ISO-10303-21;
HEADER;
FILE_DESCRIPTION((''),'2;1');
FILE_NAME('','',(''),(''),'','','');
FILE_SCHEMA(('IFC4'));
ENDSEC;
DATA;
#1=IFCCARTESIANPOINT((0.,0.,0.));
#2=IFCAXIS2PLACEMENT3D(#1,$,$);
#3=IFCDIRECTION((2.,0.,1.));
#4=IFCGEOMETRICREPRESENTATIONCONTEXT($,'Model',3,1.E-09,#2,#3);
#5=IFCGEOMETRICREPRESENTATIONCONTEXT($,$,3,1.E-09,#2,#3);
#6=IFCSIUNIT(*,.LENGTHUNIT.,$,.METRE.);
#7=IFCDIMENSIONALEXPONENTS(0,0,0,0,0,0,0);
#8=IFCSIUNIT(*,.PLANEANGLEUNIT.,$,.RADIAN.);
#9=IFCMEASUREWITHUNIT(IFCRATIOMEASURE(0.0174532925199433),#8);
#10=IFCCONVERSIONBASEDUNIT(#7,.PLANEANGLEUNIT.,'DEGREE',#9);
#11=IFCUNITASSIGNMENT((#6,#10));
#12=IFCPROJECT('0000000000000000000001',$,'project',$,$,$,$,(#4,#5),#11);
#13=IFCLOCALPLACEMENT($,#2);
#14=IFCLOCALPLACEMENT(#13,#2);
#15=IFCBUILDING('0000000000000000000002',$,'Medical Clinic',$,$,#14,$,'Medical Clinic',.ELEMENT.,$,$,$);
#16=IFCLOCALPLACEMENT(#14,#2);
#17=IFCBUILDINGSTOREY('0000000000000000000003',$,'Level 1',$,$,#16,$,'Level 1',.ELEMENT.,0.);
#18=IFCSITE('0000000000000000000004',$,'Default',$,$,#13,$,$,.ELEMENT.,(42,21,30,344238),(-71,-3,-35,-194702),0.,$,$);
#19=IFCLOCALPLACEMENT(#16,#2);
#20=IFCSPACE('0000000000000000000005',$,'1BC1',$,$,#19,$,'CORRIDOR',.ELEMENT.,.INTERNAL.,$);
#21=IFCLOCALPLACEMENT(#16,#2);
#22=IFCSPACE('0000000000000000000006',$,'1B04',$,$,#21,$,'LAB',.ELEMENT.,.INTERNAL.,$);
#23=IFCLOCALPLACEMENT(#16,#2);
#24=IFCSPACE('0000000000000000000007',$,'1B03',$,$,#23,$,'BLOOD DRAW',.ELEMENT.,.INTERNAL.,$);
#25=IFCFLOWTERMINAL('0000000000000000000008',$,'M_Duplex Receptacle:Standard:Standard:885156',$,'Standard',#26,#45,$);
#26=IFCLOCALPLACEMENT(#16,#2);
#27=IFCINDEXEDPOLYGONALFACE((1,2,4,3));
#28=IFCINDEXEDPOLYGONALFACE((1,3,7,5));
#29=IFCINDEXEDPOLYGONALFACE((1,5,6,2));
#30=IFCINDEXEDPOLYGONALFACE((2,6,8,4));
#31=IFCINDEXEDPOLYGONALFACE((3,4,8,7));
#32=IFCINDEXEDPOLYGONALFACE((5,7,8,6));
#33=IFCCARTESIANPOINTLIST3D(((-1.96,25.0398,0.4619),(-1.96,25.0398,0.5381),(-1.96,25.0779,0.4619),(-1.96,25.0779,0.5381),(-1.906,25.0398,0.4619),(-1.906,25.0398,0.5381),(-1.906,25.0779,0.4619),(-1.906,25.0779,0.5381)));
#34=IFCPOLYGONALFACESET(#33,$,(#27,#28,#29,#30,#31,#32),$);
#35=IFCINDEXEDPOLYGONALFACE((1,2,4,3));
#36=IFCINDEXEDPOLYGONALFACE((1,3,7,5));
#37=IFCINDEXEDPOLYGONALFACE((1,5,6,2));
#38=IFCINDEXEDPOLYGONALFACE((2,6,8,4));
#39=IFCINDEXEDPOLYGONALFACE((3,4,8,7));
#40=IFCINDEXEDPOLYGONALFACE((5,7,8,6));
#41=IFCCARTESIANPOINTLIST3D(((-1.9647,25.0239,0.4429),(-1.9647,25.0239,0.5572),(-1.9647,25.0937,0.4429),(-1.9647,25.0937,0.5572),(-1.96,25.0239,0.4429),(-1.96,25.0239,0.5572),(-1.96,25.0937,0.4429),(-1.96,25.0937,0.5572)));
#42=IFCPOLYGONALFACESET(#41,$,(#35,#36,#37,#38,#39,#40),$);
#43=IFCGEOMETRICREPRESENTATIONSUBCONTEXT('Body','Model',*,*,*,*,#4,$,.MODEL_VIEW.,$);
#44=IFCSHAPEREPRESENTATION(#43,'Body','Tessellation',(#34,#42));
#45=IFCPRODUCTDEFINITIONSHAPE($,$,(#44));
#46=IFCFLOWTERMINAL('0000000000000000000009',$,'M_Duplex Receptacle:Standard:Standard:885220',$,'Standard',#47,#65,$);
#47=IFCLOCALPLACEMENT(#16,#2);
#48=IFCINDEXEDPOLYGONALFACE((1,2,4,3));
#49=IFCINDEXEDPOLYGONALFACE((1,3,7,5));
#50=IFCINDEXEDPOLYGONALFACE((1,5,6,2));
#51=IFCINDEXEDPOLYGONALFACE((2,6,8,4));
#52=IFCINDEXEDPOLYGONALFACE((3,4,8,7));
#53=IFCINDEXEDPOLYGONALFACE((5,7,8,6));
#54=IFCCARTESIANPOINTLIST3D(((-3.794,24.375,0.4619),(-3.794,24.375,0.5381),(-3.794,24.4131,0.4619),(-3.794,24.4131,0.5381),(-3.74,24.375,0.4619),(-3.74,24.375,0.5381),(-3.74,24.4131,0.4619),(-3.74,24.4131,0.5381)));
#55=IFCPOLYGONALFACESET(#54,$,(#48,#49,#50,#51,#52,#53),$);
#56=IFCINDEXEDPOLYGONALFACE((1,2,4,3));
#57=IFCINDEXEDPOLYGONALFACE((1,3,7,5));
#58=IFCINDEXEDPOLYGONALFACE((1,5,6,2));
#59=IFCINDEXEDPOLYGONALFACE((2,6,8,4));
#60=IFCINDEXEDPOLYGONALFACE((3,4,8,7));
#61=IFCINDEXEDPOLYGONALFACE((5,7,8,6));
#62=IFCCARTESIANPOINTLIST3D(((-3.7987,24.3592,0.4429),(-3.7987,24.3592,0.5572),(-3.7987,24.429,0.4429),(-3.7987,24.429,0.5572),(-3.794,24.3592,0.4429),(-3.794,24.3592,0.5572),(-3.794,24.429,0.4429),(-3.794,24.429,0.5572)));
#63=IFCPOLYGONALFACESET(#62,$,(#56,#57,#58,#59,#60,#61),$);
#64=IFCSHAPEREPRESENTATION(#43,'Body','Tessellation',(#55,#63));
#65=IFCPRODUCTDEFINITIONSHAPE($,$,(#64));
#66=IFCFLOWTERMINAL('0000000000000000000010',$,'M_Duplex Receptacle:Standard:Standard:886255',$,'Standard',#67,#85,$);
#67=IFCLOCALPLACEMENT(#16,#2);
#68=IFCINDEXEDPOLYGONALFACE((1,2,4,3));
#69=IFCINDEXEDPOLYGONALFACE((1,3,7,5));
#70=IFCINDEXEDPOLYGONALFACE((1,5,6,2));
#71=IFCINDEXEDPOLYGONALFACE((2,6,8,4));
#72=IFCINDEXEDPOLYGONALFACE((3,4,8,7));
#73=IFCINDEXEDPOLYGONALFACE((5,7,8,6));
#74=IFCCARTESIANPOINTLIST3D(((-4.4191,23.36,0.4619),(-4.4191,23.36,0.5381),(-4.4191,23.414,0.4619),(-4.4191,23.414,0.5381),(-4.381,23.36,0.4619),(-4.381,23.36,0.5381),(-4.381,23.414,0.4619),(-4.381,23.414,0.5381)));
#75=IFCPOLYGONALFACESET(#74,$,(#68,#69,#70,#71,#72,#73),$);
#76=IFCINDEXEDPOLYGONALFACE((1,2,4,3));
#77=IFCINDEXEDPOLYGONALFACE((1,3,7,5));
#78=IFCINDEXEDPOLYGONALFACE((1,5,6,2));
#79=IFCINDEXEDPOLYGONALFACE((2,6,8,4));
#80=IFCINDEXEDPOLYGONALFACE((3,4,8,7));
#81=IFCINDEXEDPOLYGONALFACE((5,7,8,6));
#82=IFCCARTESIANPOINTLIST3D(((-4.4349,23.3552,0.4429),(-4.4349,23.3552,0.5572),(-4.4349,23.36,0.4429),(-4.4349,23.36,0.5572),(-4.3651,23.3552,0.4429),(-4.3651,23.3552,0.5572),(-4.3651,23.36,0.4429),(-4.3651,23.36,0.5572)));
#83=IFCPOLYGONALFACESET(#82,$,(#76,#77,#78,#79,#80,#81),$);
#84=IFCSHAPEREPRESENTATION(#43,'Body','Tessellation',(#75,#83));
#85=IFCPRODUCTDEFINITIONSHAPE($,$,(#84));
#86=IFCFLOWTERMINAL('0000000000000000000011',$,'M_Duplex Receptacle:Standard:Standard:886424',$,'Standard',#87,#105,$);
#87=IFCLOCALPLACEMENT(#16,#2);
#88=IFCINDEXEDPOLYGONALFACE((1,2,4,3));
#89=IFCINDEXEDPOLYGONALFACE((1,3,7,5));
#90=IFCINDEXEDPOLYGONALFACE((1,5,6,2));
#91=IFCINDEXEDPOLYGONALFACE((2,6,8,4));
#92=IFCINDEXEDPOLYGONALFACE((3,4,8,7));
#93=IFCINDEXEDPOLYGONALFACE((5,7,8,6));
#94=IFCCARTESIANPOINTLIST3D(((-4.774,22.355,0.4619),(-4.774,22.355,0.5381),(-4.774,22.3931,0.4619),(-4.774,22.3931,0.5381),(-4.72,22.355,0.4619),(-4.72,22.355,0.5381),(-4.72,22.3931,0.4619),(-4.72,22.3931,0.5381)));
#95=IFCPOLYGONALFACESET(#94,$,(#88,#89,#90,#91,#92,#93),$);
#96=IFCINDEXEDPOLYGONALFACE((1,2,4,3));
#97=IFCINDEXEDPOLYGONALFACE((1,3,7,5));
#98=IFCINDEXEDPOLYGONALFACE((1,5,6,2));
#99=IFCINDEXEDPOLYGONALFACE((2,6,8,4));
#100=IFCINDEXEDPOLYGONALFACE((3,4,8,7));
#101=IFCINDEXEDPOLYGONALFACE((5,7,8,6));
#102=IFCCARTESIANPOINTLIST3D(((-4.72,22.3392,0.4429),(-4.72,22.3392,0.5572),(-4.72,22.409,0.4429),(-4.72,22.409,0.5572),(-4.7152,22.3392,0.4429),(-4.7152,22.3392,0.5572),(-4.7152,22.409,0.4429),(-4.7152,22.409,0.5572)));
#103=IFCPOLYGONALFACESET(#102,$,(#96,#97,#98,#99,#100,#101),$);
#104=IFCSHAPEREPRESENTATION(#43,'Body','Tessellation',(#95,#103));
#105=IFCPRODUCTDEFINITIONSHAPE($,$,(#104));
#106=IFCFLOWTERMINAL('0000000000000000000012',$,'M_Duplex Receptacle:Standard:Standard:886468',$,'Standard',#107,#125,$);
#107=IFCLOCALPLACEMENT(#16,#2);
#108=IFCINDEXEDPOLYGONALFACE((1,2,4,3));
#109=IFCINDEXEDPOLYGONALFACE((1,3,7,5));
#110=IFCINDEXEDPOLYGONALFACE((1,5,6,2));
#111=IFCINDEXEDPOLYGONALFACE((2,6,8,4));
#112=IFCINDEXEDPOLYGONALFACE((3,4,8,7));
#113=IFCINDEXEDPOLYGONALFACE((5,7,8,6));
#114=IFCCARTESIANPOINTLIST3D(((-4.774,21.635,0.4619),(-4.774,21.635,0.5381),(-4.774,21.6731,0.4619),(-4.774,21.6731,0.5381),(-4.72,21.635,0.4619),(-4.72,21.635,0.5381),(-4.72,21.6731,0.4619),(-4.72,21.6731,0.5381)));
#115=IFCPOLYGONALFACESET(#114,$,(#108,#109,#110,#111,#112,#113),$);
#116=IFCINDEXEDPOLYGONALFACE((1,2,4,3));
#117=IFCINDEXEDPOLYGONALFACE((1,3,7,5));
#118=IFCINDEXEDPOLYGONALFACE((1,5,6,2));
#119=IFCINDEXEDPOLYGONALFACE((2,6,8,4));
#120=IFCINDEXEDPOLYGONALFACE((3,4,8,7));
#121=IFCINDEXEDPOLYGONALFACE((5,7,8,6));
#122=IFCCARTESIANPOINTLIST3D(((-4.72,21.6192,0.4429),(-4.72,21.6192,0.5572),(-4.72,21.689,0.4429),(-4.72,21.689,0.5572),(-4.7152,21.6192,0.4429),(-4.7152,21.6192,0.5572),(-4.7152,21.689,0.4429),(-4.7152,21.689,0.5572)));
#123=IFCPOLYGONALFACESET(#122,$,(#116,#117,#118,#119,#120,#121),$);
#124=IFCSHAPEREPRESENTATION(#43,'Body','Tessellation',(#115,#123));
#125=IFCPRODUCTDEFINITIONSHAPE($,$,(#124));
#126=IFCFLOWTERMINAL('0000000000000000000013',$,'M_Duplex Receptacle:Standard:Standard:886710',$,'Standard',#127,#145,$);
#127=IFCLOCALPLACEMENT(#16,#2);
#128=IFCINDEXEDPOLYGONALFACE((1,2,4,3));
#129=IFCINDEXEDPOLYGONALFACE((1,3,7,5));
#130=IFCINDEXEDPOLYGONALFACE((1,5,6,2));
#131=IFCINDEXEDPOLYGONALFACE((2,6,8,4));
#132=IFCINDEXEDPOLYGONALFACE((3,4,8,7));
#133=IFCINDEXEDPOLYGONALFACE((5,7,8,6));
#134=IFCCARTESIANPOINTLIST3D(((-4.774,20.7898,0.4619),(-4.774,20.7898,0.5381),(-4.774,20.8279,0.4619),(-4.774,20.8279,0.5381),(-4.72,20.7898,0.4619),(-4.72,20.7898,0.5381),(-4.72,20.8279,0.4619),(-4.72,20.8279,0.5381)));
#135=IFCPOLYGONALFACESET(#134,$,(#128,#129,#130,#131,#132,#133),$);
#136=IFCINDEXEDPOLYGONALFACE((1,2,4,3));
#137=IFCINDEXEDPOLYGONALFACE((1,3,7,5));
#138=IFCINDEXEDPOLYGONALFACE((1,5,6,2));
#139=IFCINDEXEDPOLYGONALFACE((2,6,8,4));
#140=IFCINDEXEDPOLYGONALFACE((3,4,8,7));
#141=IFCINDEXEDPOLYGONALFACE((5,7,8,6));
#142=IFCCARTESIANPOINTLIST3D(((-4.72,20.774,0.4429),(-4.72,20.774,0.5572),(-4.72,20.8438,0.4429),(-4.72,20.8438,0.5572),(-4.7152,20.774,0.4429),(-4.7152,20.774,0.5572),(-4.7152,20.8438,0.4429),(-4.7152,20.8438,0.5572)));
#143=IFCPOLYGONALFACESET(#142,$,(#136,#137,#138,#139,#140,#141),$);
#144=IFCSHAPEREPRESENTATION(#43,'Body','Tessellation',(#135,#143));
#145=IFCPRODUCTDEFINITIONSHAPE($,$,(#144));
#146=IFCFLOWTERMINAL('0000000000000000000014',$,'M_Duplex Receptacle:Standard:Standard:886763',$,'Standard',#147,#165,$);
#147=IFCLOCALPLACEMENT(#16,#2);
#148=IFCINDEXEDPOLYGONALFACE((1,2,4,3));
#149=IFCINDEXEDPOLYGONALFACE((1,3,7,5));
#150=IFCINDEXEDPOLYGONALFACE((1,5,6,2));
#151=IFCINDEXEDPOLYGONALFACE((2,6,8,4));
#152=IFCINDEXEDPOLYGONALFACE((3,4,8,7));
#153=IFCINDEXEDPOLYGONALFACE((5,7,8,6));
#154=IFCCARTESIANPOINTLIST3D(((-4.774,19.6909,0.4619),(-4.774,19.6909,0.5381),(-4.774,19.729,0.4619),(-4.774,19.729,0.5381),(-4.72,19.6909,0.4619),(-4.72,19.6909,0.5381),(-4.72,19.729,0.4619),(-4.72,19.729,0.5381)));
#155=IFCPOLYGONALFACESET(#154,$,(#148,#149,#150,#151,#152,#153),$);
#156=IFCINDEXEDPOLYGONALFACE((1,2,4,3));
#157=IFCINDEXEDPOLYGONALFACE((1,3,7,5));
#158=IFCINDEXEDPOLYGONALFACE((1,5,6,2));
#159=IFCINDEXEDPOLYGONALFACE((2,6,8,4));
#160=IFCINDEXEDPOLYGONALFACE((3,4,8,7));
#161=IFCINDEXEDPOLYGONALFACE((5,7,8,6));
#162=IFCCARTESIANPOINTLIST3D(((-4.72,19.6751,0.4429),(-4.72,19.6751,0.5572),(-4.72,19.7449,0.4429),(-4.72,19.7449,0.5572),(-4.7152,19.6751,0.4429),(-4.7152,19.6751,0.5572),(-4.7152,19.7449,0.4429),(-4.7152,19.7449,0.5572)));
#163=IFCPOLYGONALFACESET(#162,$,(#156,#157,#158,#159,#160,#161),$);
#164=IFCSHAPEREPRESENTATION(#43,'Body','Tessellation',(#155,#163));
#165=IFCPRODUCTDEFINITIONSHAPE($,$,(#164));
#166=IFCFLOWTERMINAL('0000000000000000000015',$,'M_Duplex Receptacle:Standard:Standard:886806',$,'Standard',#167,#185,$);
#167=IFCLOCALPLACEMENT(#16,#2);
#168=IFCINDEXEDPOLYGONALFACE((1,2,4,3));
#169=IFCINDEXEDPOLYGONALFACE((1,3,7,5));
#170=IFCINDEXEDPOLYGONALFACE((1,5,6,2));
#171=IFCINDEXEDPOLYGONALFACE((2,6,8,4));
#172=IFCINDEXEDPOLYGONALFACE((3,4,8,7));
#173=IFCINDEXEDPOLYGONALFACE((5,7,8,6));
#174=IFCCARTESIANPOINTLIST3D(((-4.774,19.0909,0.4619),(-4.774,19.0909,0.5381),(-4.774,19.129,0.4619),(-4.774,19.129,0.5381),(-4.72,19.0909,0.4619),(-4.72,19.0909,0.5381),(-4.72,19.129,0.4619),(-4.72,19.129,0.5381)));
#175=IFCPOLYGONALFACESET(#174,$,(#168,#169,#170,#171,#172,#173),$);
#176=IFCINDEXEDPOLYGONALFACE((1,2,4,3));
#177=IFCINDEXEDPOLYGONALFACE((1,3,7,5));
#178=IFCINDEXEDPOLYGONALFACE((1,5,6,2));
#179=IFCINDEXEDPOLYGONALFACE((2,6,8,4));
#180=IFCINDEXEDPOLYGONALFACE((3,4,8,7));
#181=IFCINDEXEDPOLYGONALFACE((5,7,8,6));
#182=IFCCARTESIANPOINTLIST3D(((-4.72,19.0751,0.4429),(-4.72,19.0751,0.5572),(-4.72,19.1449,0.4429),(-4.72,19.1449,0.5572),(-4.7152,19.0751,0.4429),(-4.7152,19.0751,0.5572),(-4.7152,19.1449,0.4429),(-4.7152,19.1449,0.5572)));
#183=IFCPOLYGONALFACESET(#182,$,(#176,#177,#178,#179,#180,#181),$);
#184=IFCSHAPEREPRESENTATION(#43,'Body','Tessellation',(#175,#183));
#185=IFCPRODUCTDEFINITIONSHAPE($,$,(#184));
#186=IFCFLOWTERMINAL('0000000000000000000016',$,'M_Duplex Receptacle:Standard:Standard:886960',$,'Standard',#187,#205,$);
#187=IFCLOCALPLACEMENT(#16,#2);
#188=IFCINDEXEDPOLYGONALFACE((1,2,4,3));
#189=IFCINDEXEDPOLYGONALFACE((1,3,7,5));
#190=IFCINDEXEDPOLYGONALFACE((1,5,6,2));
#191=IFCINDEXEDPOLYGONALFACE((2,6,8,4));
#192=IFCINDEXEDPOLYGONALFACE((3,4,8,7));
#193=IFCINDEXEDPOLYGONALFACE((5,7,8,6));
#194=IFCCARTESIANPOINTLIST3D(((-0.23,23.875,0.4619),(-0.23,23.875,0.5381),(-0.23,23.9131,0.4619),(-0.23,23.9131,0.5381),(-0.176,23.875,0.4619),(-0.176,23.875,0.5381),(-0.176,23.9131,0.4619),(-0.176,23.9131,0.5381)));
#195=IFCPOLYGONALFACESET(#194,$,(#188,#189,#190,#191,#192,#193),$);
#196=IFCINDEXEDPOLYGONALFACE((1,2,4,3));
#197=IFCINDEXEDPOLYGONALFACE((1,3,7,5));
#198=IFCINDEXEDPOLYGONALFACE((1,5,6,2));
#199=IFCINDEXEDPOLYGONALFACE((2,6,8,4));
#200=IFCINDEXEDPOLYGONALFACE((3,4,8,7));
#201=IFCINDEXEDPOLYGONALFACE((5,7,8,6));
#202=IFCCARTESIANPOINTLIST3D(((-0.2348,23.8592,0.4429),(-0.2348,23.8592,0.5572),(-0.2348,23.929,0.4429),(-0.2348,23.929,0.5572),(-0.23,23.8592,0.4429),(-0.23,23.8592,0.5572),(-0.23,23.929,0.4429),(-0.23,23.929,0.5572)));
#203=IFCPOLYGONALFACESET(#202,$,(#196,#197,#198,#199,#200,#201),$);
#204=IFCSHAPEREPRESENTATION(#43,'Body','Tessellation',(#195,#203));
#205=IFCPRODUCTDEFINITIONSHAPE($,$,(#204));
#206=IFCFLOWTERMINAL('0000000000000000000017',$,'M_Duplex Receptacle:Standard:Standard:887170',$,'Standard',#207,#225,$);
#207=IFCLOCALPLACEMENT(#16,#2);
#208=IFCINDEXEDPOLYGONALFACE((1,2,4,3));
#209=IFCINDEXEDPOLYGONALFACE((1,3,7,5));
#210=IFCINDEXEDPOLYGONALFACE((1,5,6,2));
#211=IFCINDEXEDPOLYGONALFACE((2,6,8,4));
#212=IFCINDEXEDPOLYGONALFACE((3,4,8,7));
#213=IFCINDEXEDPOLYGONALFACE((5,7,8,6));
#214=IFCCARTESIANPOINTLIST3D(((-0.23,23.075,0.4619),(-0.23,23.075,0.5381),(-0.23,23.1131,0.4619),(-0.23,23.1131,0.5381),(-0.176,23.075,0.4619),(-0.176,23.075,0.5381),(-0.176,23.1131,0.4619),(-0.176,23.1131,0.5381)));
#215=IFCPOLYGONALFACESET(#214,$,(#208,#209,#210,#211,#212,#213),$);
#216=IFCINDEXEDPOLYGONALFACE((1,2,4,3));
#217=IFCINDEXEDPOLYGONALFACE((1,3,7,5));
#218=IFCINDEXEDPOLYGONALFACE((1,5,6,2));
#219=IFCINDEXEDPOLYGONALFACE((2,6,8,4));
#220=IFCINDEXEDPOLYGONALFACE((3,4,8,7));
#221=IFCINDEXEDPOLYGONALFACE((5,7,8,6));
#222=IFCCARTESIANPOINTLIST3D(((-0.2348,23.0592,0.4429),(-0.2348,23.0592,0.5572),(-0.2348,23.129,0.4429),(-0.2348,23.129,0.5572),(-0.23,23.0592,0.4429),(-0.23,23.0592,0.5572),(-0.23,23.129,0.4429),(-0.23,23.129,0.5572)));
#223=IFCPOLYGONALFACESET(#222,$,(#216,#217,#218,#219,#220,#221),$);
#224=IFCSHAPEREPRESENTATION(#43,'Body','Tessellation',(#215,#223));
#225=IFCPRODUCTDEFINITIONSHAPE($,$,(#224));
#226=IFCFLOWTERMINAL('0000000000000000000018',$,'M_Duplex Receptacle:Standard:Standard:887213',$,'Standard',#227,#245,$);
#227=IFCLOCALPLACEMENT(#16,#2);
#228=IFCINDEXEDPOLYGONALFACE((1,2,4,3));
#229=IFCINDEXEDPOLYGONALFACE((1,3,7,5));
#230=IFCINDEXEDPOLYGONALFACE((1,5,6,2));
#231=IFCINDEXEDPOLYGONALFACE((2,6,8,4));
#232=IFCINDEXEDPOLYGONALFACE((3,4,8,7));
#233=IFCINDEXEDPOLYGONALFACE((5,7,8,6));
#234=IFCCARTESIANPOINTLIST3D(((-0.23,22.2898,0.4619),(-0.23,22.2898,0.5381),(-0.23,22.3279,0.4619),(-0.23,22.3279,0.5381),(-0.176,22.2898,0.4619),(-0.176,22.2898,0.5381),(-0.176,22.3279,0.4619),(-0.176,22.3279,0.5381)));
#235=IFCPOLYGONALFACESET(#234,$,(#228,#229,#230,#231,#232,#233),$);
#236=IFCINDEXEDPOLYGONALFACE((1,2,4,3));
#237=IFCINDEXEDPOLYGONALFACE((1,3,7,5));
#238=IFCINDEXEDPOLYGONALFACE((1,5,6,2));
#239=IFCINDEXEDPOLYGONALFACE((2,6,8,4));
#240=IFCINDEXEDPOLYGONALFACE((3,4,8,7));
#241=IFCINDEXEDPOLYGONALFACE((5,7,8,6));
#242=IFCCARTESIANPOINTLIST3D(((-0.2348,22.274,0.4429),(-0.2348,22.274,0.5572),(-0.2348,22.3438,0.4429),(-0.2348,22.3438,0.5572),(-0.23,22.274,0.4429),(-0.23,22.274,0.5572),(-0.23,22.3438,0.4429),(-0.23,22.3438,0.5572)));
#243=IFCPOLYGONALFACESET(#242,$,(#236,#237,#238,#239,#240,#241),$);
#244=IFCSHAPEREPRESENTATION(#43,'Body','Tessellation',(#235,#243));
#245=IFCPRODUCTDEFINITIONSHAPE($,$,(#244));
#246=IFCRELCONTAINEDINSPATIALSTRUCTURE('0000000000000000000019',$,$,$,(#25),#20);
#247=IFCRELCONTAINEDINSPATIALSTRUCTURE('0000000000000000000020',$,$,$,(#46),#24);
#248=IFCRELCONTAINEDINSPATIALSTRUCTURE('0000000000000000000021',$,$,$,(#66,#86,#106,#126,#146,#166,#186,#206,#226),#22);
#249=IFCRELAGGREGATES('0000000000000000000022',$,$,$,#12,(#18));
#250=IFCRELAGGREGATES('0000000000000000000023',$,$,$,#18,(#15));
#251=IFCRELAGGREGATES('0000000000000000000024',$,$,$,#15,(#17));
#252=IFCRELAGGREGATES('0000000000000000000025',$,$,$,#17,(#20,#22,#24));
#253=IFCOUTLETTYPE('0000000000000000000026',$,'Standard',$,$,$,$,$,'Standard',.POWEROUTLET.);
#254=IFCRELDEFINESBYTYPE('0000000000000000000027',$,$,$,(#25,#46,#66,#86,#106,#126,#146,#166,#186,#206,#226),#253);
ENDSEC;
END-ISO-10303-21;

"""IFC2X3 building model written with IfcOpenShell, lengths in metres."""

from ifc_helpers import new_model, entity, si_unit, converted_unit, direction, frame, frame_2d, origin, origin_2d_with_axis, place, context, subcontext, project, spatial, rectangle, extrude, source, transform, mapped, type_object, type_shapes, element, save


model = new_model("IFC2X3")

# Units and contexts
model_context = context("Model", 3, precision=1e-09, world=origin(), true_north=direction((2.0, 0.0, 1.0)))
context_of_model = context(None, 3, precision=1e-09, world=origin(), true_north=direction((2.0, 0.0, 1.0)))
body_context = subcontext(model_context, "Body", "Model", "MODEL_VIEW")
ifc_project = project(units=[si_unit("LENGTHUNIT", "METRE"), converted_unit("PLANEANGLEUNIT", "DEGREE", entity("IfcRatioMeasure", 0.0174532925199433), si_unit("PLANEANGLEUNIT", "RADIAN"), dimensions=[0, 0, 0, 0, 0, 0, 0])], contexts=[model_context, context_of_model])

# Site, building, storey
site_placement = place(None, origin())
site = spatial("IfcSite", under=ifc_project, at=site_placement, Name="Default", CompositionType="ELEMENT", RefLatitude=(42, 21, 30, 344238), RefLongitude=(-71, -3, -35, -194702), RefElevation=0.0)
building_placement = place(site_placement, origin())
building = spatial("IfcBuilding", under=site, at=building_placement, Name="Medical Clinic", LongName="Medical Clinic", CompositionType="ELEMENT")
storey_placement = place(building_placement, origin())
storey = spatial("IfcBuildingStorey", under=building, at=storey_placement, Name="Level 1", LongName="Level 1", CompositionType="ELEMENT", Elevation=0.0)

# Shared definitions
space_1_placement = place(storey_placement, origin())
space_1 = spatial("IfcSpace", under=storey, at=space_1_placement, Name="1BC1", LongName="CORRIDOR", CompositionType="ELEMENT", InteriorOrExteriorSpace="INTERNAL")

# Shared definitions
space_2_placement = place(storey_placement, origin())
space_2 = spatial("IfcSpace", under=storey, at=space_2_placement, Name="1B04", LongName="LAB", CompositionType="ELEMENT", InteriorOrExteriorSpace="INTERNAL")

# Flow terminal
outlet_type = type_object("IfcOutletType", Name="Standard", ElementType="Standard", PredefinedType="POWEROUTLET")
shared_shape_1 = source(origin(), body_context, "Body", "SweptSolid", [
    extrude(rectangle(XDim=0.0381, YDim=0.0762, at=origin_2d_with_axis()), frame((0.0, 0.0, -0.054), z_axis=(0.0, 0.0, 1.0), x_axis=(-1.0, 0.0, 0.0)), (0.0, 0.0, 1.0), 0.054),
    extrude(rectangle(XDim=0.0698, YDim=0.1143, at=frame_2d((0.0, 0.0), x_axis=(1.0, 0.0))), frame((0.0, 0.0, 0.0), z_axis=(0.0, 0.0, 1.0), x_axis=(-1.0, 0.0, 0.0)), (0.0, 0.0, 1.0), 0.0048),
])
type_shapes(outlet_type, [shared_shape_1])
flow_terminal_1_placement = place(space_1_placement, frame((-1.96, 25.0588, 0.5), z_axis=(-1.0, 0.0, 0.0), x_axis=(0.0, -1.0, 0.0)))
element("IfcFlowTerminal", 1, at=flow_terminal_1_placement, inside=space_1, type_object=outlet_type, Name="M_Duplex Receptacle:Standard:Standard:885156", ObjectType="Standard", context=body_context, shape_type="MappedRepresentation", body=[
    mapped(shared_shape_1, transform((0.0, 0.0, 0.0), scale=1.0)),
])

# Shared definitions
space_3_placement = place(storey_placement, origin())
space_3 = spatial("IfcSpace", under=storey, at=space_3_placement, Name="1B03", LongName="BLOOD DRAW", CompositionType="ELEMENT", InteriorOrExteriorSpace="INTERNAL")

# Flow terminals
flow_terminal_2_placement = place(space_3_placement, frame((-3.794, 24.3941, 0.5), z_axis=(-1.0, 0.0, 0.0), x_axis=(0.0, -1.0, 0.0)))
element("IfcFlowTerminal", 2, at=flow_terminal_2_placement, inside=space_3, type_object=outlet_type, Name="M_Duplex Receptacle:Standard:Standard:885220", ObjectType="Standard", context=body_context, shape_type="MappedRepresentation", body=[
    mapped(shared_shape_1, transform((0.0, 0.0, 0.0), scale=1.0)),
])
for number, where, z_axis, x_axis, name in (
    (3, (-4.4, 23.36, 0.5), (0.0, -1.0, 0.0), (1.0, 0.0, 0.0), "M_Duplex Receptacle:Standard:Standard:886255"),
    (4, (-4.72, 22.3741, 0.5), (1.0, 0.0, 0.0), (0.0, 1.0, 0.0), "M_Duplex Receptacle:Standard:Standard:886424"),
    (5, (-4.72, 21.6541, 0.5), (1.0, 0.0, 0.0), (0.0, 1.0, 0.0), "M_Duplex Receptacle:Standard:Standard:886468"),
    (6, (-4.72, 20.8089, 0.5), (1.0, 0.0, 0.0), (0.0, 1.0, 0.0), "M_Duplex Receptacle:Standard:Standard:886710"),
    (7, (-4.72, 19.71, 0.5), (1.0, 0.0, 0.0), (0.0, 1.0, 0.0), "M_Duplex Receptacle:Standard:Standard:886763"),
    (8, (-4.72, 19.11, 0.5), (1.0, 0.0, 0.0), (0.0, 1.0, 0.0), "M_Duplex Receptacle:Standard:Standard:886806"),
    (9, (-0.23, 23.8941, 0.5), (-1.0, 0.0, 0.0), (0.0, -1.0, 0.0), "M_Duplex Receptacle:Standard:Standard:886960"),
    (10, (-0.23, 23.0941, 0.5), (-1.0, 0.0, 0.0), (0.0, -1.0, 0.0), "M_Duplex Receptacle:Standard:Standard:887170"),
    (11, (-0.23, 22.3089, 0.5), (-1.0, 0.0, 0.0), (0.0, -1.0, 0.0), "M_Duplex Receptacle:Standard:Standard:887213"),
):
    element("IfcFlowTerminal", number, at=place(space_2_placement, frame(where, z_axis=z_axis, x_axis=x_axis)), inside=space_2, type_object=outlet_type, Name=name, ObjectType="Standard", context=body_context, shape_type="MappedRepresentation", body=[
        mapped(shared_shape_1, transform((0.0, 0.0, 0.0), scale=1.0)),
    ])

save(model, "model.ifc")
